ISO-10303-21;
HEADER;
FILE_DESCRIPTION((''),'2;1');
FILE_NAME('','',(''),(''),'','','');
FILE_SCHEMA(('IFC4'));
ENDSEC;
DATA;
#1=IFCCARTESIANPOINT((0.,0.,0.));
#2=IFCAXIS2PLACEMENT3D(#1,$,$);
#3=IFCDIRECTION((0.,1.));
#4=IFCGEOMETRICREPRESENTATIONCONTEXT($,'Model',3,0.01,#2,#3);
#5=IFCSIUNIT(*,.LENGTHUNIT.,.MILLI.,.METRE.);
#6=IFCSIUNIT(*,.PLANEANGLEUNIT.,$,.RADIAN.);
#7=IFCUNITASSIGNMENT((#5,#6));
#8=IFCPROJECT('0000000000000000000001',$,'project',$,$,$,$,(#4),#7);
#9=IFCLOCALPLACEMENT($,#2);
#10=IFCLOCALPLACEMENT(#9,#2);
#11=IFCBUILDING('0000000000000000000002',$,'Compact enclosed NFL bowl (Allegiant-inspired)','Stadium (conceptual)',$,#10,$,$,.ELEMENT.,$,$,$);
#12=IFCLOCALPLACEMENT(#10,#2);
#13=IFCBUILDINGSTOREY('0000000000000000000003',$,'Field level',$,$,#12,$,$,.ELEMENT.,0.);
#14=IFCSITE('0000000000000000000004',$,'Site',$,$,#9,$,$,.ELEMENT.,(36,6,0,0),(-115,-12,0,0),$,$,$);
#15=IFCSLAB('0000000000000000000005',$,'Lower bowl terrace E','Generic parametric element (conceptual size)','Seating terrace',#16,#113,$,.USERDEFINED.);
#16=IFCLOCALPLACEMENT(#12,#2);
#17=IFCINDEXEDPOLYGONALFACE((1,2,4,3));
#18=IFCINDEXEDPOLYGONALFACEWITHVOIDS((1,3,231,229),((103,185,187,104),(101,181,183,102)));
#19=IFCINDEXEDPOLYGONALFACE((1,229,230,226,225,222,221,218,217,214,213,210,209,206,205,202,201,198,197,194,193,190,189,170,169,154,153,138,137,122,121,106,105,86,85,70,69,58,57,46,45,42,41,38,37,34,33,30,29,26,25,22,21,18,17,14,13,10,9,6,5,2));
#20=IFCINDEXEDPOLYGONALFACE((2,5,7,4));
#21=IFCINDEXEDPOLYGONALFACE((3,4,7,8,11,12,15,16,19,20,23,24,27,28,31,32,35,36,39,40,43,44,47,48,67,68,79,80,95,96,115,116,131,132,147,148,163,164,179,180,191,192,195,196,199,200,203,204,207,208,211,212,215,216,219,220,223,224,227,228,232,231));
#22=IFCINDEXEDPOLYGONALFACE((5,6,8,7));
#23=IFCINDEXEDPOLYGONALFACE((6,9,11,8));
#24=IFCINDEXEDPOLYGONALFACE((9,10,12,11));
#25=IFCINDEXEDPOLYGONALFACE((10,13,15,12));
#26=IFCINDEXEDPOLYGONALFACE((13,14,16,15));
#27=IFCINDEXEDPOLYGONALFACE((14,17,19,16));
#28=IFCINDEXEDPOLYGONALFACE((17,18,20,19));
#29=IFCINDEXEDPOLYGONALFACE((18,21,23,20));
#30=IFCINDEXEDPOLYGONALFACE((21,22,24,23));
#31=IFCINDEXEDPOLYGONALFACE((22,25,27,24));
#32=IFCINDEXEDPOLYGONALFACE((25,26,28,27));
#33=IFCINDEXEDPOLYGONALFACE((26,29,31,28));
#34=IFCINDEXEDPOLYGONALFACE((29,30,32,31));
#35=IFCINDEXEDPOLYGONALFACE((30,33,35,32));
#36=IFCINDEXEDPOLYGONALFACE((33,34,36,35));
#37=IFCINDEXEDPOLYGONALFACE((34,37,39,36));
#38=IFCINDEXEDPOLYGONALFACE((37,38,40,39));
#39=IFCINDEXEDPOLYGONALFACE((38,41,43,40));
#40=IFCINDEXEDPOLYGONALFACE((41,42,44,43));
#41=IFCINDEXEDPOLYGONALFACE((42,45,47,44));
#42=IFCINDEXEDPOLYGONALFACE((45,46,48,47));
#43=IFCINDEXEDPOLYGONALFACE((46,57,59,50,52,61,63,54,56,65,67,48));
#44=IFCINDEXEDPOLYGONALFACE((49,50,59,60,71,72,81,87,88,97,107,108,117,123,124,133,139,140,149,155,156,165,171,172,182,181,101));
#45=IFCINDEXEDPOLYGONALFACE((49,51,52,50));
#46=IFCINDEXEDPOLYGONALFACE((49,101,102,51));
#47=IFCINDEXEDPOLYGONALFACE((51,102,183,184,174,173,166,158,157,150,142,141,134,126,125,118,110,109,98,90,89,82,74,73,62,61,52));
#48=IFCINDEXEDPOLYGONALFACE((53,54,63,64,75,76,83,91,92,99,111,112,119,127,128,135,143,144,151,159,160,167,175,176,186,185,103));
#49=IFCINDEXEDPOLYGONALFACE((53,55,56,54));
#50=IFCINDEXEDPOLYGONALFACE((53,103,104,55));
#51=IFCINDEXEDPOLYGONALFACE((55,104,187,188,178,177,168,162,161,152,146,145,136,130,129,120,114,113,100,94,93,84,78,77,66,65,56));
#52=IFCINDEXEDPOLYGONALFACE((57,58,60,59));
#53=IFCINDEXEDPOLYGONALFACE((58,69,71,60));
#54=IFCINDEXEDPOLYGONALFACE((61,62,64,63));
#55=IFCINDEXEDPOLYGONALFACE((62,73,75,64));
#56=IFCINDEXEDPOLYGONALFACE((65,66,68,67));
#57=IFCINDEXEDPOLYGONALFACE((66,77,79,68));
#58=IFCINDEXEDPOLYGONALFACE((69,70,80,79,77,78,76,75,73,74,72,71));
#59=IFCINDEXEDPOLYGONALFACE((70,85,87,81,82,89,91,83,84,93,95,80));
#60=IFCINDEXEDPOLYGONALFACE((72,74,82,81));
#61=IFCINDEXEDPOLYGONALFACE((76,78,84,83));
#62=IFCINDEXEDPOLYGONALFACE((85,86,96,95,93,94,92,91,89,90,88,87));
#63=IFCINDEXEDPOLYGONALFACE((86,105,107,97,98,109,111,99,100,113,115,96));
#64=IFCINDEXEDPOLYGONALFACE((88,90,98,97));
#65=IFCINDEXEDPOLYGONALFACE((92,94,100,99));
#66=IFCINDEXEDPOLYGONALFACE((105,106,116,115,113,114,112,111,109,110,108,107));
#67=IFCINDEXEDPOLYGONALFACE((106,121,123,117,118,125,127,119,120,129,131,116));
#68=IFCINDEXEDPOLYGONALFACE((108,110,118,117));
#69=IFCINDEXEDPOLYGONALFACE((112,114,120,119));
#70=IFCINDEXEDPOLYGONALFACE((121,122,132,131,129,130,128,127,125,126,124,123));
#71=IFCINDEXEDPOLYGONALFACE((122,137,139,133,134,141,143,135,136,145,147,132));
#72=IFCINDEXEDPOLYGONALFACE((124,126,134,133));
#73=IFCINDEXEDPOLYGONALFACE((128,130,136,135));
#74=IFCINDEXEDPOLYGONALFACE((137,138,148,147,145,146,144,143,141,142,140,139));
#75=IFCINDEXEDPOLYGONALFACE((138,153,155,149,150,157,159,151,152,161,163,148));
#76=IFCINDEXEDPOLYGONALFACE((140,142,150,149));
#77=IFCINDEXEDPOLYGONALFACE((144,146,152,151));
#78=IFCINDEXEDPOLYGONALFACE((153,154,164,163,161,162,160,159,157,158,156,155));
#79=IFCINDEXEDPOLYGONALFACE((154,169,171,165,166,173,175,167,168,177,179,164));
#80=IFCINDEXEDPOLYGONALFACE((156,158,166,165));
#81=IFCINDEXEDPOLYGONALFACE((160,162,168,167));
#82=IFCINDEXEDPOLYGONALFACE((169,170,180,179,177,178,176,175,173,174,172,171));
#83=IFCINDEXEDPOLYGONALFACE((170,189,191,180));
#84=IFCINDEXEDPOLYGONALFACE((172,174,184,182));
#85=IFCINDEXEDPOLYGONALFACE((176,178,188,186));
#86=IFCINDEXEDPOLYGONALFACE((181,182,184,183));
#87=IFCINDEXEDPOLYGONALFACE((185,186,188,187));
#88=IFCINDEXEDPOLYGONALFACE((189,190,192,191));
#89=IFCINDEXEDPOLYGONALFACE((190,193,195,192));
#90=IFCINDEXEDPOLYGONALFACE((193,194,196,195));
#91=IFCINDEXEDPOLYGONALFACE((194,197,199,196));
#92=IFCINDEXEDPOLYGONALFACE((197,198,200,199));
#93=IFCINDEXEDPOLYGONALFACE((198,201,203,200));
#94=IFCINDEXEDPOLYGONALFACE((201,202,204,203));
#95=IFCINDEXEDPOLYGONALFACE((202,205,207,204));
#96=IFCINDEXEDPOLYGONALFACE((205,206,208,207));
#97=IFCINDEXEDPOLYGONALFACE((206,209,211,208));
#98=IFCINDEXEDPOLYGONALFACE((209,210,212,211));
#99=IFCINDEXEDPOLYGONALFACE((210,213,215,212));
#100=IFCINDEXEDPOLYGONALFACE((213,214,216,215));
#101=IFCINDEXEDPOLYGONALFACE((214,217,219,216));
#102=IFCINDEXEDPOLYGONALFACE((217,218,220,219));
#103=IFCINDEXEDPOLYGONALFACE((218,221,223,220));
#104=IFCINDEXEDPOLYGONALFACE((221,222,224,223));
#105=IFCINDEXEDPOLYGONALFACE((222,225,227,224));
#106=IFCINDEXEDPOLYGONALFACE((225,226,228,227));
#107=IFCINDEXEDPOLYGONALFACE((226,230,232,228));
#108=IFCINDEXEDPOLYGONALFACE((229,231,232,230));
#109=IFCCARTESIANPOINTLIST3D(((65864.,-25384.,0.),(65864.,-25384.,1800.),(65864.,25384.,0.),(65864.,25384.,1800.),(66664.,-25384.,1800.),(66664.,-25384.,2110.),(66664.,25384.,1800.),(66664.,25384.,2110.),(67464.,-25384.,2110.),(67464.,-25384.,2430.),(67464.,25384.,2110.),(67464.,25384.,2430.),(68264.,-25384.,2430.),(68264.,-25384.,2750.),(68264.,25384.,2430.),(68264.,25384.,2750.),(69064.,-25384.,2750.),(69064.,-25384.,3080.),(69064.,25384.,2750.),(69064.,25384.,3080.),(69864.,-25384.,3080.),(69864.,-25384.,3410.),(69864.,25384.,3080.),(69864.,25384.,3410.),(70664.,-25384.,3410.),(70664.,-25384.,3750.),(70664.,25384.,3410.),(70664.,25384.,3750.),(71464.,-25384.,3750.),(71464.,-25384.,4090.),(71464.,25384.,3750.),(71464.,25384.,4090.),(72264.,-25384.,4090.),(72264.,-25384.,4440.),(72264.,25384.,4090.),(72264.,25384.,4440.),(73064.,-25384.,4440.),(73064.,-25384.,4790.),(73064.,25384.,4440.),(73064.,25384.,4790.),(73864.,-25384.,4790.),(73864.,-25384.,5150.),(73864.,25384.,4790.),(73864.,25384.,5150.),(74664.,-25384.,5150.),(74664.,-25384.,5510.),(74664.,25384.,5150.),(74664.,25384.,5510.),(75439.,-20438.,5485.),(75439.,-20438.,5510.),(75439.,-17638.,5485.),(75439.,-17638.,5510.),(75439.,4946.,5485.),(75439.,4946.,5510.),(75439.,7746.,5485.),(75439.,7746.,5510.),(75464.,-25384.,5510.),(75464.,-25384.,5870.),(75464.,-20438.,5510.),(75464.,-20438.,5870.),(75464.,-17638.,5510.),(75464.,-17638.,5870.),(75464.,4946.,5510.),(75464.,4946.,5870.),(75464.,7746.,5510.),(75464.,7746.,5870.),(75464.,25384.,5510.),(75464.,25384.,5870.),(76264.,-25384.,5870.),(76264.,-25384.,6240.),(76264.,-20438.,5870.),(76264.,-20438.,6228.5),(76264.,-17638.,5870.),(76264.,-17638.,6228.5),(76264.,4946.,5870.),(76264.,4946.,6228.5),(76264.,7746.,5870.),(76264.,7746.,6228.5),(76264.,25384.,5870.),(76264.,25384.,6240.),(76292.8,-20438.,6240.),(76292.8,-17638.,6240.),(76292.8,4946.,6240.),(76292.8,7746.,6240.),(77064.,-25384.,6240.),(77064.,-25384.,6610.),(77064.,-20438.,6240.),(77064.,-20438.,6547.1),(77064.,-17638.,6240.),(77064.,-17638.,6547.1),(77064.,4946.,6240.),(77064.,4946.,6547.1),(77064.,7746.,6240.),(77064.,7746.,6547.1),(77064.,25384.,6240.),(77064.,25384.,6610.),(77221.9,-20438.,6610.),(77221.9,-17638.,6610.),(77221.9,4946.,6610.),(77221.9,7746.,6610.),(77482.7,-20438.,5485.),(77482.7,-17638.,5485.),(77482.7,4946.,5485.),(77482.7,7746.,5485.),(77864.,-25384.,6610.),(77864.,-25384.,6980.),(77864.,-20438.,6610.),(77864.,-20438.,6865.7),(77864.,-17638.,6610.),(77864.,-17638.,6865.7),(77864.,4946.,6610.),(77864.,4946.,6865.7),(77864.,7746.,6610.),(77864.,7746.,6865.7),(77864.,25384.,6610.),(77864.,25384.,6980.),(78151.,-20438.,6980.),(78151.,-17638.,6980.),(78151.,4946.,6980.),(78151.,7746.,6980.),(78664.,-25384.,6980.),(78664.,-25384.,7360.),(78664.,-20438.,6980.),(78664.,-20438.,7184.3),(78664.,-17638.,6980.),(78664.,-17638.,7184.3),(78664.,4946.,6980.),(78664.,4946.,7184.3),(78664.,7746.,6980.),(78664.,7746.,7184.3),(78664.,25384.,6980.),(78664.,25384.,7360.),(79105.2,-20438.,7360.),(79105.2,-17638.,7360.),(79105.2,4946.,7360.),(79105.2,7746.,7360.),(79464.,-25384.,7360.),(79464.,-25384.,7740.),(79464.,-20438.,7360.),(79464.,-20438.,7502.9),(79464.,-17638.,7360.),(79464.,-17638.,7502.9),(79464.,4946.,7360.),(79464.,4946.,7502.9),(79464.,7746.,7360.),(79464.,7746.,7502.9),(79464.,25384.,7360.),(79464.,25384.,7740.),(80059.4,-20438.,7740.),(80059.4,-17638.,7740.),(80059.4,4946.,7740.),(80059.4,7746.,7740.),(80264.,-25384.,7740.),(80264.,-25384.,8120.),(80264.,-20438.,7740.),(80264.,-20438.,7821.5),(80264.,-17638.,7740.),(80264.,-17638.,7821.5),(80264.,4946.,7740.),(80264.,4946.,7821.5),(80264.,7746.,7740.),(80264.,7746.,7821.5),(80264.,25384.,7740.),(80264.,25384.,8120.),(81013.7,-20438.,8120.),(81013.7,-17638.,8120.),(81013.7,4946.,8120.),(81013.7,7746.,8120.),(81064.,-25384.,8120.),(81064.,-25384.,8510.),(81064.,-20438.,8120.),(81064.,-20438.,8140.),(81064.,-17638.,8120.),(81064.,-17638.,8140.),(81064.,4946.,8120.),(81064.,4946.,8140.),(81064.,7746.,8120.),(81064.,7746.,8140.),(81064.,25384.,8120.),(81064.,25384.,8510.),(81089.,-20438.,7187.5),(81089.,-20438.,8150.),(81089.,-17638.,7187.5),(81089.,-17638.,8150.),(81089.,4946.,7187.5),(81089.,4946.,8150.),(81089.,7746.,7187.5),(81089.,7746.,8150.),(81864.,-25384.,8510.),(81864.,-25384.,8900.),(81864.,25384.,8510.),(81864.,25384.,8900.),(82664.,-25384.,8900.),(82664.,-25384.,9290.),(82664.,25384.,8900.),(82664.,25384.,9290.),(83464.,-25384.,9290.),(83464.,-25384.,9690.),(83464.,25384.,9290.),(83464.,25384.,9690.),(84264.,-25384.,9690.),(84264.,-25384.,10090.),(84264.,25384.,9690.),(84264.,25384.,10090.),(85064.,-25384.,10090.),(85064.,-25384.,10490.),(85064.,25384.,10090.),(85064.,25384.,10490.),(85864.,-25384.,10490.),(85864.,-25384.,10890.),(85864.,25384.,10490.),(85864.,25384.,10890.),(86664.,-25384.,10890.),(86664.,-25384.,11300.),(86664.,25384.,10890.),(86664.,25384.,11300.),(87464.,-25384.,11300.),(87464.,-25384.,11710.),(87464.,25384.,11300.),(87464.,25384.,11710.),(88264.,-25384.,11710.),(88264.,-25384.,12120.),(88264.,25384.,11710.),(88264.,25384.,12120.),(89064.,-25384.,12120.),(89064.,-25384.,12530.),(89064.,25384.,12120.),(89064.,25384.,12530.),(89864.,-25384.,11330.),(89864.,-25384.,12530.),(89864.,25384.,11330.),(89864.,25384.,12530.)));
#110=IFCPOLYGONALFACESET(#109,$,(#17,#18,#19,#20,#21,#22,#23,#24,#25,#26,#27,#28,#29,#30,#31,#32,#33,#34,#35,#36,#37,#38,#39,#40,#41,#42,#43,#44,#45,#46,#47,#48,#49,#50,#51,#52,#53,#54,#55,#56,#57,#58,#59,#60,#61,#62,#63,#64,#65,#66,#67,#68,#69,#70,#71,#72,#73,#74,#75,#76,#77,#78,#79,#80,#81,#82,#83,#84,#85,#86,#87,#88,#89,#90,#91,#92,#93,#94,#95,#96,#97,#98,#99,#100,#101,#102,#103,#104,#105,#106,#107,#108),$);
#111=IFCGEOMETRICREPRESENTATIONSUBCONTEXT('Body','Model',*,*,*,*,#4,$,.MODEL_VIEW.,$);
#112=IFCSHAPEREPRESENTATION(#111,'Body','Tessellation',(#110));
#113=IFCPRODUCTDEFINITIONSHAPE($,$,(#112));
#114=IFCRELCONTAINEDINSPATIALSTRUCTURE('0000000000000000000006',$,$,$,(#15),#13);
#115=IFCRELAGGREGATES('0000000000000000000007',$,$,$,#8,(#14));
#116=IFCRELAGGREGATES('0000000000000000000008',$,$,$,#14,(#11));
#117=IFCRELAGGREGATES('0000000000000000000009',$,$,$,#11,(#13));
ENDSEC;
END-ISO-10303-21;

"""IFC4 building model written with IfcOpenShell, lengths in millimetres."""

from ifc_helpers import new_model, si_unit, direction, frame, origin, place, context, subcontext, project, spatial, line, indexed_curve, outline, extrude, element, save


model = new_model("IFC4")

# Units and contexts
model_context = context("Model", 3, precision=0.01, world=origin(), true_north=direction((0.0, 1.0)))
body_context = subcontext(model_context, "Body", "Model", "MODEL_VIEW")
ifc_project = project(units=[si_unit("LENGTHUNIT", "METRE", prefix="MILLI"), si_unit("PLANEANGLEUNIT", "RADIAN")], contexts=[model_context])

# Site, building, storey
site_placement = place(None, origin())
site = spatial("IfcSite", under=ifc_project, at=site_placement, Name="Site", CompositionType="ELEMENT", RefLatitude=(36, 6, 0, 0), RefLongitude=(-115, -12, 0, 0))
building_placement = place(site_placement, origin())
building = spatial("IfcBuilding", under=site, at=building_placement, Name="Compact enclosed NFL bowl (Allegiant-inspired)", Description="Stadium (conceptual)", CompositionType="ELEMENT")
storey_placement = place(building_placement, origin())
storey = spatial("IfcBuildingStorey", under=building, at=storey_placement, Name="Field level", CompositionType="ELEMENT", Elevation=0.0)

# Shared definitions
placement = place(storey_placement, origin())

# Slab, openings
slab_1 = element("IfcSlab", 1, at=placement, inside=storey, Name="Lower bowl terrace E", Description="Generic parametric element (conceptual size)", ObjectType="Seating terrace", PredefinedType="USERDEFINED", context=body_context, shape_type="SweptSolid", body=[
    extrude(outline(indexed_curve([(24000.0, 11330.0), (24000.0, 12530.0), (23200.0, 12530.0), (23200.0, 12120.0), (22400.0, 12120.0), (22400.0, 11710.0), (21600.0, 11710.0), (21600.0, 11300.0), (20800.0, 11300.0), (20800.0, 10890.0), (20000.0, 10890.0), (20000.0, 10490.0), (19200.0, 10490.0), (19200.0, 10090.0), (18400.0, 10090.0), (18400.0, 9690.0), (17600.0, 9690.0), (17600.0, 9290.0), (16800.0, 9290.0), (16800.0, 8900.0), (16000.0, 8900.0), (16000.0, 8510.0), (15200.0, 8510.0), (15200.0, 8120.0), (14400.0, 8120.0), (14400.0, 7740.0), (13600.0, 7740.0), (13600.0, 7360.0), (12800.0, 7360.0), (12800.0, 6980.0), (12000.0, 6980.0), (12000.0, 6610.0), (11200.0, 6610.0), (11200.0, 6240.0), (10400.0, 6240.0), (10400.0, 5870.0), (9600.0, 5870.0), (9600.0, 5510.0), (8800.0, 5510.0), (8800.0, 5150.0), (8000.0, 5150.0), (8000.0, 4790.0), (7200.0, 4790.0), (7200.0, 4440.0), (6400.0, 4440.0), (6400.0, 4090.0), (5600.0, 4090.0), (5600.0, 3750.0), (4800.0, 3750.0), (4800.0, 3410.0), (4000.0, 3410.0), (4000.0, 3080.0), (3200.0, 3080.0), (3200.0, 2750.0), (2400.0, 2750.0), (2400.0, 2430.0), (1600.0, 2430.0), (1600.0, 2110.0), (800.0, 2110.0), (800.0, 1800.0), (0.0, 1800.0), (0.0, 0.0)], segments=[line(1, 2, 3, 4, 5, 6, 7, 8, 9, 10, 11, 12, 13, 14, 15, 16, 17, 18, 19, 20, 21, 22, 23, 24, 25, 26, 27, 28, 29, 30, 31, 32, 33, 34, 35, 36, 37, 38, 39, 40, 41, 42, 43, 44, 45, 46, 47, 48, 49, 50, 51, 52, 53, 54, 55, 56, 57, 58, 59, 60, 61, 62, 1)], self_intersect=False)), frame((65864.0, 25384.0, 0.0), z_axis=(0.0, -1.0, 0.0), x_axis=(1.0, 0.0, 0.0)), (0.0, 0.0, 1.0), 50768.0),
])
opening_1_placement = place(placement, origin())
element("IfcOpeningElement", 2, at=opening_1_placement, cuts=slab_1, ObjectType="Vomitory", PredefinedType="OPENING", context=body_context, shape_type="SweptSolid", body=[
    extrude(outline(indexed_curve([(9575.0, 5485.0), (15225.0, 5485.0), (15225.0, 8150.0), (9575.0, 5900.0)], segments=[line(1, 2, 3, 4, 1)], self_intersect=False)), frame((65864.0, -17638.0, 0.0), z_axis=(0.0, -1.0, 0.0), x_axis=(1.0, 0.0, 0.0)), (0.0, 0.0, 1.0), 2800.0),
])
opening_2_placement = place(placement, origin())
element("IfcOpeningElement", 3, at=opening_2_placement, cuts=slab_1, ObjectType="Vomitory", PredefinedType="OPENING", context=body_context, shape_type="SweptSolid", body=[
    extrude(outline(indexed_curve([(9575.0, 5485.0), (15225.0, 5485.0), (15225.0, 8150.0), (9575.0, 5900.0)], segments=[line(1, 2, 3, 4, 1)], self_intersect=False)), frame((65864.0, 7746.0, 0.0), z_axis=(0.0, -1.0, 0.0), x_axis=(1.0, 0.0, 0.0)), (0.0, 0.0, 1.0), 2800.0),
])

save(model, "model.ifc")
